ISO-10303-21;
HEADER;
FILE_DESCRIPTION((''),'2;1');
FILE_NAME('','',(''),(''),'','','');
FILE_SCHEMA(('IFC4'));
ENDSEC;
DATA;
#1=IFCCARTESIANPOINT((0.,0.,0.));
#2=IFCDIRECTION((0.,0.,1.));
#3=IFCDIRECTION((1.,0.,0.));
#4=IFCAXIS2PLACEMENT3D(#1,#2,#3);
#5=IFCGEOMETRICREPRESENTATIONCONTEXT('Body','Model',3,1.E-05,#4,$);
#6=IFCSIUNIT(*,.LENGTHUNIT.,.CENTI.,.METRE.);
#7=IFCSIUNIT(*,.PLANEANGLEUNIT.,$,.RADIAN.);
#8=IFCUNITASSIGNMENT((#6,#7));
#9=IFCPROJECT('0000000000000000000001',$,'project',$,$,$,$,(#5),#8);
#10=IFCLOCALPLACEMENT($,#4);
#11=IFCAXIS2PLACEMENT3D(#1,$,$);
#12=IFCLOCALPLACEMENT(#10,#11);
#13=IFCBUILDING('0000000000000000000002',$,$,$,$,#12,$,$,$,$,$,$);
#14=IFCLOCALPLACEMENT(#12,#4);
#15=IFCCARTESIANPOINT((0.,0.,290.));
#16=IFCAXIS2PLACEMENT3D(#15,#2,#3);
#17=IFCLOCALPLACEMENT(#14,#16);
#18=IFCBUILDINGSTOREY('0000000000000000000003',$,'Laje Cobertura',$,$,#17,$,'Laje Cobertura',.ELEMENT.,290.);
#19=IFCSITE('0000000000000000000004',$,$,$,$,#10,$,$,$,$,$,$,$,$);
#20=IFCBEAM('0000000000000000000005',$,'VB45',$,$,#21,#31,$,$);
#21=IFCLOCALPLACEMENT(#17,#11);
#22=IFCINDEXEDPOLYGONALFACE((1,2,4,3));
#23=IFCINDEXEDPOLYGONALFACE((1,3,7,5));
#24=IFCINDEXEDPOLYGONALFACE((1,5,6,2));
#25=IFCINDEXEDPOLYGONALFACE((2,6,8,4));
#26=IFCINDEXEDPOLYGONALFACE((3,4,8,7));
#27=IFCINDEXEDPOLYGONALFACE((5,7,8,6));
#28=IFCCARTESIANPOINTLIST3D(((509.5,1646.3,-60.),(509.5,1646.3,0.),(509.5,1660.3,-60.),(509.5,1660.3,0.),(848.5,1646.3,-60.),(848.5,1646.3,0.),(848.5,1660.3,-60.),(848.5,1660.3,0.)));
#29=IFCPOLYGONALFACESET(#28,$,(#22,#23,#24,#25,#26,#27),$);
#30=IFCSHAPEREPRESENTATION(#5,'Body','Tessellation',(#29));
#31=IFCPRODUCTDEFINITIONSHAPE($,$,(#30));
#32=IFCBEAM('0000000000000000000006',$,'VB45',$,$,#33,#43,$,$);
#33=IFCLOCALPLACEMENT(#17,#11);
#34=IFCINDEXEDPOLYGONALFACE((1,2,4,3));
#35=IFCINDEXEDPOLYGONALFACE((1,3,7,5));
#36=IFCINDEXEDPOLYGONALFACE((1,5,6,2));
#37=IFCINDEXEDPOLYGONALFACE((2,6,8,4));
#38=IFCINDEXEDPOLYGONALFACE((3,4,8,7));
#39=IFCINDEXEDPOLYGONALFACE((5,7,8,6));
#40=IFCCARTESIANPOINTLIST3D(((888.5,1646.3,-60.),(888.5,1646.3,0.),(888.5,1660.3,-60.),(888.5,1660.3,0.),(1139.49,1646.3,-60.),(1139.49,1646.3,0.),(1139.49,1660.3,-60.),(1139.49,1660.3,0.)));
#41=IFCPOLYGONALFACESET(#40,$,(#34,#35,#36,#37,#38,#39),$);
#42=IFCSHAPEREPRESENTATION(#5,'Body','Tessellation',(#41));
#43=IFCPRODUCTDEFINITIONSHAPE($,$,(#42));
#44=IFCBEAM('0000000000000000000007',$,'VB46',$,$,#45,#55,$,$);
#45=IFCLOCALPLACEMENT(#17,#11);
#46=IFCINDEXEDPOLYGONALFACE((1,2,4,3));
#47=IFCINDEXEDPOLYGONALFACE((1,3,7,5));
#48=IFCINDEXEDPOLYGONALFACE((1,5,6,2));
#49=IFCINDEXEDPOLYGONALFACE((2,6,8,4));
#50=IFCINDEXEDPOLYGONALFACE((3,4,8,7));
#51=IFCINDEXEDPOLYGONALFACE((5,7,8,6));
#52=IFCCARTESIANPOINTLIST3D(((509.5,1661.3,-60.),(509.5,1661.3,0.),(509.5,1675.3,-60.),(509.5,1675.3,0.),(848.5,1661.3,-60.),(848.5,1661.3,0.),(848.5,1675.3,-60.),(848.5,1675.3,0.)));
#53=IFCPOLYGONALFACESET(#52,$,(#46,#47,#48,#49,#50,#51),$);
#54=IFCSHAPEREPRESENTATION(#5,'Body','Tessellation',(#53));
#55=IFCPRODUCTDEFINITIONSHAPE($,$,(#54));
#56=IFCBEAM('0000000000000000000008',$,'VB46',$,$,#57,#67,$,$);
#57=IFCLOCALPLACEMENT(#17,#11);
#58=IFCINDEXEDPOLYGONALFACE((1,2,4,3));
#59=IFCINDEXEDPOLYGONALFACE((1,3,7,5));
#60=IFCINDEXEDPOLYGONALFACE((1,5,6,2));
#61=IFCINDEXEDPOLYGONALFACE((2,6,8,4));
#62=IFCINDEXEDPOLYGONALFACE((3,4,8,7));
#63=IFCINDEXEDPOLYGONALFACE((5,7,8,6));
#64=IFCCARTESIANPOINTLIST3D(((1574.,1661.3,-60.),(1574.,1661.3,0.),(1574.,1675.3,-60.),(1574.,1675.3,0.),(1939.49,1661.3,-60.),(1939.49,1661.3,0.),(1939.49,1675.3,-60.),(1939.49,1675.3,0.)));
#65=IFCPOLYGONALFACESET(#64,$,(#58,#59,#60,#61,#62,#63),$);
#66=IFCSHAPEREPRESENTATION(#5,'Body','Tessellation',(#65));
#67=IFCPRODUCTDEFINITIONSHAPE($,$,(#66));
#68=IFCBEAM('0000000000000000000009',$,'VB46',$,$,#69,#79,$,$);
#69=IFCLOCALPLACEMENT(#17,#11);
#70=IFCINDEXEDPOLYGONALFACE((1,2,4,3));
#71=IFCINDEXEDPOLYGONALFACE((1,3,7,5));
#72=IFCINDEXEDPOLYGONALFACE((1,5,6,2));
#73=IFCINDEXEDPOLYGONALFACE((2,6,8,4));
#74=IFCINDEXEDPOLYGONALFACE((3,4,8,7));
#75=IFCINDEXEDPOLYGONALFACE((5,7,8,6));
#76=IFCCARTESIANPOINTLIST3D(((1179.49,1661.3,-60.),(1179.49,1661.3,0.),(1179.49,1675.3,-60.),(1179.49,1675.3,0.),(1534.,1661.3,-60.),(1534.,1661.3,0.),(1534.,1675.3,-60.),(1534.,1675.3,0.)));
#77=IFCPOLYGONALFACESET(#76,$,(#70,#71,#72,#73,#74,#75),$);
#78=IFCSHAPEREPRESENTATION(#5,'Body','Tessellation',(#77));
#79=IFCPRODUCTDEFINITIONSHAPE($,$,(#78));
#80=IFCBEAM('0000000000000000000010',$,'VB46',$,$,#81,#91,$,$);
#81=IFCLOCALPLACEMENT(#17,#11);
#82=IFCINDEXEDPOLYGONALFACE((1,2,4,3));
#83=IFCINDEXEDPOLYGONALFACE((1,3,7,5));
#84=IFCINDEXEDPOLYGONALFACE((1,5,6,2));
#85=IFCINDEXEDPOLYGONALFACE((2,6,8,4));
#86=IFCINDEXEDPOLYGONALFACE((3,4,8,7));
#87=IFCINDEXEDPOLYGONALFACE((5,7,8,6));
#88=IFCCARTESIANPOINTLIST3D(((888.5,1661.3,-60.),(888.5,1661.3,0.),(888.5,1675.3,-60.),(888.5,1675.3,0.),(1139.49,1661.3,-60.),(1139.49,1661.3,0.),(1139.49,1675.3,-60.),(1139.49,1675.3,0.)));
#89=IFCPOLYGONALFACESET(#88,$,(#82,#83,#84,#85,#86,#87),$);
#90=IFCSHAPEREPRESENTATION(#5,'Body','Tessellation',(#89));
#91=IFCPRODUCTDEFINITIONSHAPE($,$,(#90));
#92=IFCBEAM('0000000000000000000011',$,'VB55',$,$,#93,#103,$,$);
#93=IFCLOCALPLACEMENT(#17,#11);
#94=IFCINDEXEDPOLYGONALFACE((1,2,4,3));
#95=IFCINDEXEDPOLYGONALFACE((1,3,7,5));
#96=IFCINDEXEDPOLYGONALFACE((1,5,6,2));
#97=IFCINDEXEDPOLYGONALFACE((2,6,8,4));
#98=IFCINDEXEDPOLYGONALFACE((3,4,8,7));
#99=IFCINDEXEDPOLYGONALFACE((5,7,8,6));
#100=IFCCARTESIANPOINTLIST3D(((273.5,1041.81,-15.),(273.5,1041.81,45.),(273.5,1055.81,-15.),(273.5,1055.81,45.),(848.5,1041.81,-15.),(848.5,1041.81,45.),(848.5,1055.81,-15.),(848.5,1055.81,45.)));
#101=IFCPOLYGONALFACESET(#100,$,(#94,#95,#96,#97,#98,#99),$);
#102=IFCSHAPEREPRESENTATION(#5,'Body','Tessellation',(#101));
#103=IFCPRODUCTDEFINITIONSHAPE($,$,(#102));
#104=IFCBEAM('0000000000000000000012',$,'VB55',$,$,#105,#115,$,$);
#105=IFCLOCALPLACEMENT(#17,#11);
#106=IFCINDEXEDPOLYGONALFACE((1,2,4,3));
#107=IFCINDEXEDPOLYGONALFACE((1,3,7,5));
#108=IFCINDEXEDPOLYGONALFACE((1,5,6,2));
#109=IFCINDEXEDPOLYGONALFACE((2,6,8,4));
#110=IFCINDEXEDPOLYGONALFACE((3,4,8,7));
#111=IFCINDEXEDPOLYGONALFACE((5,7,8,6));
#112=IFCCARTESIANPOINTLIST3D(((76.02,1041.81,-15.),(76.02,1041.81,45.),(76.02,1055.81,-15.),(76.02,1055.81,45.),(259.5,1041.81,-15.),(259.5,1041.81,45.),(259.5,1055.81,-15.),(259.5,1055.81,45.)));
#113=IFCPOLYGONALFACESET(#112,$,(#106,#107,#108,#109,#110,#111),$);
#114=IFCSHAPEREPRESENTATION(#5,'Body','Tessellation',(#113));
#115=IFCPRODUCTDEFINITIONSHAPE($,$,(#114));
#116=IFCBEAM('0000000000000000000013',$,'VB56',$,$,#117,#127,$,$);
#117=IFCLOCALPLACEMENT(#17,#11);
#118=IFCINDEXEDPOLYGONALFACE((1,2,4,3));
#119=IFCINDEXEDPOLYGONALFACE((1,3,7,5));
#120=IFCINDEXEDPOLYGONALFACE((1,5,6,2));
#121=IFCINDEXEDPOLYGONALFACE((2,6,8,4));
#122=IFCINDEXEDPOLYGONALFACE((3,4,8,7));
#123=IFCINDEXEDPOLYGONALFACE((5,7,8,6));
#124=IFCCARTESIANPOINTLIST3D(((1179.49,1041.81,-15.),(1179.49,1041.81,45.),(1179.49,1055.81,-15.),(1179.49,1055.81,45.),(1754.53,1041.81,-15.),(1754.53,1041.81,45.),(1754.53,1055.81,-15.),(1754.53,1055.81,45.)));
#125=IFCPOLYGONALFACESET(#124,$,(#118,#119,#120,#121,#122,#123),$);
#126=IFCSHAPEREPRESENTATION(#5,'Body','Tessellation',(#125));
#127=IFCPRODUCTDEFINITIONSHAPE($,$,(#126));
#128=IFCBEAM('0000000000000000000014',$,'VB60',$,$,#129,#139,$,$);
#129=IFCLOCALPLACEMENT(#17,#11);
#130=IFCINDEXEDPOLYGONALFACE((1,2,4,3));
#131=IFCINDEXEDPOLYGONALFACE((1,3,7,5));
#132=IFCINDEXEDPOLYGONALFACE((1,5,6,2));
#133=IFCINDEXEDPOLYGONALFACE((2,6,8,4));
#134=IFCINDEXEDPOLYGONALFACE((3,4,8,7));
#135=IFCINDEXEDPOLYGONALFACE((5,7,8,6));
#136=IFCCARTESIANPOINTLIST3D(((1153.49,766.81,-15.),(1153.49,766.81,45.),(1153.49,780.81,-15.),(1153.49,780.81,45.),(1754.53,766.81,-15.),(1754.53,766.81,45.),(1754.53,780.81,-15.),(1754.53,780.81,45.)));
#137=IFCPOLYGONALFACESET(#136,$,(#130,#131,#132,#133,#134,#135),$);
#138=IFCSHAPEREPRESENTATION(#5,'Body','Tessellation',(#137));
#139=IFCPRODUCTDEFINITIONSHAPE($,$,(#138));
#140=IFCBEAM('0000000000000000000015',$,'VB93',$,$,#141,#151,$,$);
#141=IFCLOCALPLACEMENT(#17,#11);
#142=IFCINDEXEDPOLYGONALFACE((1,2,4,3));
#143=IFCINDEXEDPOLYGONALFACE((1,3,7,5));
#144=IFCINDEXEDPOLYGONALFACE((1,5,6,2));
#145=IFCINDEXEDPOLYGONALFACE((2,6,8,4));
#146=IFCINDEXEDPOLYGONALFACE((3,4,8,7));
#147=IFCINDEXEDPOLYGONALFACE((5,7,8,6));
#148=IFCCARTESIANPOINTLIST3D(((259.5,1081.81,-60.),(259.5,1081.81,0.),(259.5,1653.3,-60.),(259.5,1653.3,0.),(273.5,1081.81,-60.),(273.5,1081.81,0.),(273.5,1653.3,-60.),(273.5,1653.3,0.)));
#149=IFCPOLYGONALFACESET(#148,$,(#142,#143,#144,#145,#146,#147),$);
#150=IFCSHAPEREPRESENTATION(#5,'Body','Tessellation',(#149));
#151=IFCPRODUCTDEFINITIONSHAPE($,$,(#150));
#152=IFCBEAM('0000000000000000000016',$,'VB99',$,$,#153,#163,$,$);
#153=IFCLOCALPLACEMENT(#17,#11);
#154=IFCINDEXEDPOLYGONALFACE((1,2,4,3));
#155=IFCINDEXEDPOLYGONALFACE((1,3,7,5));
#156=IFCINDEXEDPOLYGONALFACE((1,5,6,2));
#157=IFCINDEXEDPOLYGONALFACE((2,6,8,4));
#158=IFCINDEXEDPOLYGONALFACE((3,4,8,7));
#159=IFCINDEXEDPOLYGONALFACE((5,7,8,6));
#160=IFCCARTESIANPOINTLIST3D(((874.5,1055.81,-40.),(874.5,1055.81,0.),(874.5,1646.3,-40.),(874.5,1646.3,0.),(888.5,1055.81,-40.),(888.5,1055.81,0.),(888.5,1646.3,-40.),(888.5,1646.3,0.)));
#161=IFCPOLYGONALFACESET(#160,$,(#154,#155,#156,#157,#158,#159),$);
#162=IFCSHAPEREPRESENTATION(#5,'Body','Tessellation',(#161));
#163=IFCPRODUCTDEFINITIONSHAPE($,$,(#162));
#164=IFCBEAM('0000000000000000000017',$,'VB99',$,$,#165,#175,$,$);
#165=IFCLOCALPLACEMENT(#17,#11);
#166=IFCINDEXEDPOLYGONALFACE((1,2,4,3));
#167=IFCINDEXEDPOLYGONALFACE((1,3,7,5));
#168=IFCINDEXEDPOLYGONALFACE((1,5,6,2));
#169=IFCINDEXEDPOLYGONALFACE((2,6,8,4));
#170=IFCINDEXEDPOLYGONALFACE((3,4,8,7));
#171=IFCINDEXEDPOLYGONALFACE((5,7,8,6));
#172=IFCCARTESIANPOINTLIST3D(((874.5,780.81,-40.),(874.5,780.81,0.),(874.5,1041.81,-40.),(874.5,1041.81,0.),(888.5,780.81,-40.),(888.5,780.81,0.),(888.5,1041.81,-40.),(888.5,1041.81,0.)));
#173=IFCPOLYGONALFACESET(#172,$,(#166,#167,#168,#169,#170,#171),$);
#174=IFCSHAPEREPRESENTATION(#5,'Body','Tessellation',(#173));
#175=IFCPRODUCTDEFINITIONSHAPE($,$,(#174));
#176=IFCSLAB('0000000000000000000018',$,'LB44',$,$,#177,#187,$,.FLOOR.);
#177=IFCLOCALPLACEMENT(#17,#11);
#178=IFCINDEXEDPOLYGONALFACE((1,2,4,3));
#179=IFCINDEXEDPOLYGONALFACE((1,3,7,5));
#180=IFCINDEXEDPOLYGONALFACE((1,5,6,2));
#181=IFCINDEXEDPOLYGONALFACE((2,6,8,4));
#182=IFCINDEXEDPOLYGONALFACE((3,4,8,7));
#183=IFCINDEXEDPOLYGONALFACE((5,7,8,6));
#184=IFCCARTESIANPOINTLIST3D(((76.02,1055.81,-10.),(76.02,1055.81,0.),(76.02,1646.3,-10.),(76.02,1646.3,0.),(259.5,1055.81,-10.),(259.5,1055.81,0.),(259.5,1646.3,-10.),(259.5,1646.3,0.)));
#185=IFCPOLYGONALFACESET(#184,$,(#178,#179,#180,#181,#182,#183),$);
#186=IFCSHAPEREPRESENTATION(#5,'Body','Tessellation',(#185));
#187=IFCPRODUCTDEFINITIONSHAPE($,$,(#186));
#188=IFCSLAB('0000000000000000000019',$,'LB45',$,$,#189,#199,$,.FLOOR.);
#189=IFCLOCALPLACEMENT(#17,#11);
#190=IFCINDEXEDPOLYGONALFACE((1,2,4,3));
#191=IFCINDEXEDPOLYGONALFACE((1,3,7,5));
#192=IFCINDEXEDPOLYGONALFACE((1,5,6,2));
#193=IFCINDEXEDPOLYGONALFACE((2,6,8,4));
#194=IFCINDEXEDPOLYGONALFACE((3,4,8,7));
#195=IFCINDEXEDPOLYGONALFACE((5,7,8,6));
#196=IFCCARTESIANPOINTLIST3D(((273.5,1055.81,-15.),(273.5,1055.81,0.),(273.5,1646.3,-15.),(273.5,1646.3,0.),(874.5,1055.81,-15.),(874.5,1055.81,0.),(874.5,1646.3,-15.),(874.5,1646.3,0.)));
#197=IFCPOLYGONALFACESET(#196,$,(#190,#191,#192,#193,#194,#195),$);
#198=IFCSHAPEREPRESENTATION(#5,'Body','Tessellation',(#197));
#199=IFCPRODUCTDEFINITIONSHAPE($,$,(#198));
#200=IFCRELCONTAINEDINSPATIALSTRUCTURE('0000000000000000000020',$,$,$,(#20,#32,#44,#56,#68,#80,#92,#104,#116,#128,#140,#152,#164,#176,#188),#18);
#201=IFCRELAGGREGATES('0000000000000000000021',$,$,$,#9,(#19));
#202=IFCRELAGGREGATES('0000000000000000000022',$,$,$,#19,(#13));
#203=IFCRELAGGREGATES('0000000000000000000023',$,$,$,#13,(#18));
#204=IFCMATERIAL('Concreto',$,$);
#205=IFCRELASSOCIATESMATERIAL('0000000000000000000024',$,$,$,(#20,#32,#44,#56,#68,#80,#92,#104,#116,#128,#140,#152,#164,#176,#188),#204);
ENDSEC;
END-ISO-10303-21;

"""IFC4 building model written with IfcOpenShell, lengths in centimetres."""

from ifc_helpers import new_model, si_unit, frame, origin, origin_with_axes, origin_2d_with_axis, place, context, project, spatial, polyline, rectangle, outline, extrude, material, element, save


model = new_model("IFC4")

# Units and contexts
model_context = context("Model", 3, precision=1e-05, world=origin_with_axes(), identifier="Body")
ifc_project = project(units=[si_unit("LENGTHUNIT", "METRE", prefix="CENTI"), si_unit("PLANEANGLEUNIT", "RADIAN")], contexts=[model_context])

# Site, building, storey
site_placement = place(None, origin_with_axes())
site = spatial("IfcSite", under=ifc_project, at=site_placement)
building_placement = place(site_placement, origin())
building = spatial("IfcBuilding", under=site, at=building_placement)
placement = place(building_placement, origin_with_axes())
storey_placement = place(placement, frame((0.0, 0.0, 290.0), z_axis=(0.0, 0.0, 1.0), x_axis=(1.0, 0.0, 0.0)))
storey = spatial("IfcBuildingStorey", under=building, at=storey_placement, Name="Laje Cobertura", LongName="Laje Cobertura", CompositionType="ELEMENT", Elevation=290.0)

# Shared definitions
ifc_material = material(Name="Concreto")

# Beams
beam_1_placement = place(storey_placement, frame((679.0, 1653.3, 0.0), z_axis=(0.0, 0.0, 1.0), x_axis=(1.0, 0.0, 0.0)))
element("IfcBeam", 1, at=beam_1_placement, inside=storey, material=ifc_material, Name="VB45", context=model_context, shape_type="SolidModel", body=[
    extrude(rectangle(XDim=14.0, YDim=60.0, at=origin_2d_with_axis()), frame((-169.5, 0.0, -30.0), z_axis=(1.0, 0.0, 0.0), x_axis=(0.0, 1.0, 0.0)), (0.0, 0.0, 1.0), 339.0),
])
beam_2_placement = place(storey_placement, frame((1014.0, 1653.3, 0.0), z_axis=(0.0, 0.0, 1.0), x_axis=(1.0, 0.0, 0.0)))
element("IfcBeam", 2, at=beam_2_placement, inside=storey, material=ifc_material, Name="VB45", context=model_context, shape_type="SolidModel", body=[
    extrude(rectangle(XDim=14.0, YDim=60.0, at=origin_2d_with_axis()), frame((-125.5, 0.0, -30.0), z_axis=(1.0, 0.0, 0.0), x_axis=(0.0, 1.0, 0.0)), (0.0, 0.0, 1.0), 250.99),
])
beam_3_placement = place(storey_placement, frame((679.0, 1668.3, 0.0), z_axis=(0.0, 0.0, 1.0), x_axis=(1.0, 0.0, 0.0)))
element("IfcBeam", 3, at=beam_3_placement, inside=storey, material=ifc_material, Name="VB46", context=model_context, shape_type="SolidModel", body=[
    extrude(rectangle(XDim=14.0, YDim=60.0, at=origin_2d_with_axis()), frame((-169.5, 0.0, -30.0), z_axis=(1.0, 0.0, 0.0), x_axis=(0.0, 1.0, 0.0)), (0.0, 0.0, 1.0), 339.0),
])
beam_4_placement = place(storey_placement, frame((1756.74, 1668.3, 0.0), z_axis=(0.0, 0.0, 1.0), x_axis=(1.0, 0.0, 0.0)))
element("IfcBeam", 4, at=beam_4_placement, inside=storey, material=ifc_material, Name="VB46", context=model_context, shape_type="SolidModel", body=[
    extrude(rectangle(XDim=14.0, YDim=60.0, at=origin_2d_with_axis()), frame((-182.75, 0.0, -30.0), z_axis=(1.0, 0.0, 0.0), x_axis=(0.0, 1.0, 0.0)), (0.0, 0.0, 1.0), 365.49),
])
beam_5_placement = place(storey_placement, frame((1356.74, 1668.3, 0.0), z_axis=(0.0, 0.0, 1.0), x_axis=(1.0, 0.0, 0.0)))
element("IfcBeam", 5, at=beam_5_placement, inside=storey, material=ifc_material, Name="VB46", context=model_context, shape_type="SolidModel", body=[
    extrude(rectangle(XDim=14.0, YDim=60.0, at=origin_2d_with_axis()), frame((-177.25, 0.0, -30.0), z_axis=(1.0, 0.0, 0.0), x_axis=(0.0, 1.0, 0.0)), (0.0, 0.0, 1.0), 354.51),
])
beam_6_placement = place(storey_placement, frame((1014.0, 1668.3, 0.0), z_axis=(0.0, 0.0, 1.0), x_axis=(1.0, 0.0, 0.0)))
element("IfcBeam", 6, at=beam_6_placement, inside=storey, material=ifc_material, Name="VB46", context=model_context, shape_type="SolidModel", body=[
    extrude(rectangle(XDim=14.0, YDim=60.0, at=origin_2d_with_axis()), frame((-125.5, 0.0, -30.0), z_axis=(1.0, 0.0, 0.0), x_axis=(0.0, 1.0, 0.0)), (0.0, 0.0, 1.0), 250.99),
])
beam_7_placement = place(storey_placement, frame((561.0, 1048.81, 45.0), z_axis=(0.0, 0.0, 1.0), x_axis=(1.0, 0.0, 0.0)))
element("IfcBeam", 7, at=beam_7_placement, inside=storey, material=ifc_material, Name="VB55", context=model_context, shape_type="SolidModel", body=[
    extrude(rectangle(XDim=14.0, YDim=60.0, at=origin_2d_with_axis()), frame((-287.5, 0.0, -30.0), z_axis=(1.0, 0.0, 0.0), x_axis=(0.0, 1.0, 0.0)), (0.0, 0.0, 1.0), 575.0),
])
beam_8_placement = place(storey_placement, frame((167.76, 1048.81, 45.0), z_axis=(0.0, 0.0, 1.0), x_axis=(1.0, 0.0, 0.0)))
element("IfcBeam", 8, at=beam_8_placement, inside=storey, material=ifc_material, Name="VB55", context=model_context, shape_type="SolidModel", body=[
    extrude(rectangle(XDim=14.0, YDim=60.0, at=origin_2d_with_axis()), frame((-91.74, 0.0, -30.0), z_axis=(1.0, 0.0, 0.0), x_axis=(0.0, 1.0, 0.0)), (0.0, 0.0, 1.0), 183.48),
])
beam_9_placement = place(storey_placement, frame((1467.01, 1048.81, 45.0), z_axis=(0.0, 0.0, 1.0), x_axis=(1.0, 0.0, 0.0)))
element("IfcBeam", 9, at=beam_9_placement, inside=storey, material=ifc_material, Name="VB56", context=model_context, shape_type="SolidModel", body=[
    extrude(rectangle(XDim=14.0, YDim=60.0, at=origin_2d_with_axis()), frame((-287.52, 0.0, -30.0), z_axis=(1.0, 0.0, 0.0), x_axis=(0.0, 1.0, 0.0)), (0.0, 0.0, 1.0), 575.04),
])
beam_10_placement = place(storey_placement, frame((1454.01, 773.81, 45.0), z_axis=(0.0, 0.0, 1.0), x_axis=(1.0, 0.0, 0.0)))
element("IfcBeam", 10, at=beam_10_placement, inside=storey, material=ifc_material, Name="VB60", context=model_context, shape_type="SolidModel", body=[
    extrude(rectangle(XDim=14.0, YDim=60.0, at=origin_2d_with_axis()), frame((-300.52, 0.0, -30.0), z_axis=(1.0, 0.0, 0.0), x_axis=(0.0, 1.0, 0.0)), (0.0, 0.0, 1.0), 601.04),
])
beam_11_placement = place(storey_placement, frame((266.5, 1367.56, 0.0), z_axis=(0.0, 0.0, 1.0), x_axis=(1.0, 0.0, 0.0)))
element("IfcBeam", 11, at=beam_11_placement, inside=storey, material=ifc_material, Name="VB93", context=model_context, shape_type="SolidModel", body=[
    extrude(rectangle(XDim=14.0, YDim=60.0, at=origin_2d_with_axis()), frame((0.0, -285.75, -30.0), z_axis=(0.0, 1.0, 0.0), x_axis=(-1.0, 0.0, 0.0)), (0.0, 0.0, 1.0), 571.49),
])
beam_12_placement = place(storey_placement, frame((881.5, 1351.06, 0.0), z_axis=(0.0, 0.0, 1.0), x_axis=(1.0, 0.0, 0.0)))
element("IfcBeam", 12, at=beam_12_placement, inside=storey, material=ifc_material, Name="VB99", context=model_context, shape_type="SolidModel", body=[
    extrude(rectangle(XDim=14.0, YDim=40.0, at=origin_2d_with_axis()), frame((0.0, -295.25, -20.0), z_axis=(0.0, 1.0, 0.0), x_axis=(1.0, 0.0, 0.0)), (0.0, 0.0, 1.0), 590.49),
])
beam_13_placement = place(storey_placement, frame((881.5, 911.31, 0.0), z_axis=(0.0, 0.0, 1.0), x_axis=(1.0, 0.0, 0.0)))
element("IfcBeam", 13, at=beam_13_placement, inside=storey, material=ifc_material, Name="VB99", context=model_context, shape_type="SolidModel", body=[
    extrude(rectangle(XDim=14.0, YDim=40.0, at=origin_2d_with_axis()), frame((0.0, -130.5, -20.0), z_axis=(0.0, 1.0, 0.0), x_axis=(1.0, 0.0, 0.0)), (0.0, 0.0, 1.0), 261.0),
])

# Slabs
slab_1_placement = place(storey_placement, frame((167.76, 1351.05, 0.0), z_axis=(0.0, 0.0, 1.0), x_axis=(1.0, 0.0, 0.0)))
element("IfcSlab", 14, at=slab_1_placement, inside=storey, material=ifc_material, Name="LB44", PredefinedType="FLOOR", context=model_context, shape_type="SolidModel", body=[
    extrude(outline(polyline([(91.74, -295.25), (91.74, 295.24), (-91.74, 295.24), (-91.74, -295.25), (91.74, -295.25), (91.74, -295.25)])), frame((0.0, 0.0, -10.0), z_axis=(0.0, 0.0, 1.0), x_axis=(1.0, 0.0, 0.0)), (0.0, 0.0, 1.0), 10.0),
])
slab_2_placement = place(storey_placement, frame((574.0, 1351.05, 0.0), z_axis=(0.0, 0.0, 1.0), x_axis=(1.0, 0.0, 0.0)))
element("IfcSlab", 15, at=slab_2_placement, inside=storey, material=ifc_material, Name="LB45", PredefinedType="FLOOR", context=model_context, shape_type="SolidModel", body=[
    extrude(outline(polyline([(300.5, -295.24), (300.5, 295.24), (-300.5, 295.24), (-300.5, -295.25), (300.5, -295.24), (300.5, -295.24)])), frame((0.0, 0.0, -15.0), z_axis=(0.0, 0.0, 1.0), x_axis=(1.0, 0.0, 0.0)), (0.0, 0.0, 1.0), 15.0),
])

save(model, "model.ifc")
